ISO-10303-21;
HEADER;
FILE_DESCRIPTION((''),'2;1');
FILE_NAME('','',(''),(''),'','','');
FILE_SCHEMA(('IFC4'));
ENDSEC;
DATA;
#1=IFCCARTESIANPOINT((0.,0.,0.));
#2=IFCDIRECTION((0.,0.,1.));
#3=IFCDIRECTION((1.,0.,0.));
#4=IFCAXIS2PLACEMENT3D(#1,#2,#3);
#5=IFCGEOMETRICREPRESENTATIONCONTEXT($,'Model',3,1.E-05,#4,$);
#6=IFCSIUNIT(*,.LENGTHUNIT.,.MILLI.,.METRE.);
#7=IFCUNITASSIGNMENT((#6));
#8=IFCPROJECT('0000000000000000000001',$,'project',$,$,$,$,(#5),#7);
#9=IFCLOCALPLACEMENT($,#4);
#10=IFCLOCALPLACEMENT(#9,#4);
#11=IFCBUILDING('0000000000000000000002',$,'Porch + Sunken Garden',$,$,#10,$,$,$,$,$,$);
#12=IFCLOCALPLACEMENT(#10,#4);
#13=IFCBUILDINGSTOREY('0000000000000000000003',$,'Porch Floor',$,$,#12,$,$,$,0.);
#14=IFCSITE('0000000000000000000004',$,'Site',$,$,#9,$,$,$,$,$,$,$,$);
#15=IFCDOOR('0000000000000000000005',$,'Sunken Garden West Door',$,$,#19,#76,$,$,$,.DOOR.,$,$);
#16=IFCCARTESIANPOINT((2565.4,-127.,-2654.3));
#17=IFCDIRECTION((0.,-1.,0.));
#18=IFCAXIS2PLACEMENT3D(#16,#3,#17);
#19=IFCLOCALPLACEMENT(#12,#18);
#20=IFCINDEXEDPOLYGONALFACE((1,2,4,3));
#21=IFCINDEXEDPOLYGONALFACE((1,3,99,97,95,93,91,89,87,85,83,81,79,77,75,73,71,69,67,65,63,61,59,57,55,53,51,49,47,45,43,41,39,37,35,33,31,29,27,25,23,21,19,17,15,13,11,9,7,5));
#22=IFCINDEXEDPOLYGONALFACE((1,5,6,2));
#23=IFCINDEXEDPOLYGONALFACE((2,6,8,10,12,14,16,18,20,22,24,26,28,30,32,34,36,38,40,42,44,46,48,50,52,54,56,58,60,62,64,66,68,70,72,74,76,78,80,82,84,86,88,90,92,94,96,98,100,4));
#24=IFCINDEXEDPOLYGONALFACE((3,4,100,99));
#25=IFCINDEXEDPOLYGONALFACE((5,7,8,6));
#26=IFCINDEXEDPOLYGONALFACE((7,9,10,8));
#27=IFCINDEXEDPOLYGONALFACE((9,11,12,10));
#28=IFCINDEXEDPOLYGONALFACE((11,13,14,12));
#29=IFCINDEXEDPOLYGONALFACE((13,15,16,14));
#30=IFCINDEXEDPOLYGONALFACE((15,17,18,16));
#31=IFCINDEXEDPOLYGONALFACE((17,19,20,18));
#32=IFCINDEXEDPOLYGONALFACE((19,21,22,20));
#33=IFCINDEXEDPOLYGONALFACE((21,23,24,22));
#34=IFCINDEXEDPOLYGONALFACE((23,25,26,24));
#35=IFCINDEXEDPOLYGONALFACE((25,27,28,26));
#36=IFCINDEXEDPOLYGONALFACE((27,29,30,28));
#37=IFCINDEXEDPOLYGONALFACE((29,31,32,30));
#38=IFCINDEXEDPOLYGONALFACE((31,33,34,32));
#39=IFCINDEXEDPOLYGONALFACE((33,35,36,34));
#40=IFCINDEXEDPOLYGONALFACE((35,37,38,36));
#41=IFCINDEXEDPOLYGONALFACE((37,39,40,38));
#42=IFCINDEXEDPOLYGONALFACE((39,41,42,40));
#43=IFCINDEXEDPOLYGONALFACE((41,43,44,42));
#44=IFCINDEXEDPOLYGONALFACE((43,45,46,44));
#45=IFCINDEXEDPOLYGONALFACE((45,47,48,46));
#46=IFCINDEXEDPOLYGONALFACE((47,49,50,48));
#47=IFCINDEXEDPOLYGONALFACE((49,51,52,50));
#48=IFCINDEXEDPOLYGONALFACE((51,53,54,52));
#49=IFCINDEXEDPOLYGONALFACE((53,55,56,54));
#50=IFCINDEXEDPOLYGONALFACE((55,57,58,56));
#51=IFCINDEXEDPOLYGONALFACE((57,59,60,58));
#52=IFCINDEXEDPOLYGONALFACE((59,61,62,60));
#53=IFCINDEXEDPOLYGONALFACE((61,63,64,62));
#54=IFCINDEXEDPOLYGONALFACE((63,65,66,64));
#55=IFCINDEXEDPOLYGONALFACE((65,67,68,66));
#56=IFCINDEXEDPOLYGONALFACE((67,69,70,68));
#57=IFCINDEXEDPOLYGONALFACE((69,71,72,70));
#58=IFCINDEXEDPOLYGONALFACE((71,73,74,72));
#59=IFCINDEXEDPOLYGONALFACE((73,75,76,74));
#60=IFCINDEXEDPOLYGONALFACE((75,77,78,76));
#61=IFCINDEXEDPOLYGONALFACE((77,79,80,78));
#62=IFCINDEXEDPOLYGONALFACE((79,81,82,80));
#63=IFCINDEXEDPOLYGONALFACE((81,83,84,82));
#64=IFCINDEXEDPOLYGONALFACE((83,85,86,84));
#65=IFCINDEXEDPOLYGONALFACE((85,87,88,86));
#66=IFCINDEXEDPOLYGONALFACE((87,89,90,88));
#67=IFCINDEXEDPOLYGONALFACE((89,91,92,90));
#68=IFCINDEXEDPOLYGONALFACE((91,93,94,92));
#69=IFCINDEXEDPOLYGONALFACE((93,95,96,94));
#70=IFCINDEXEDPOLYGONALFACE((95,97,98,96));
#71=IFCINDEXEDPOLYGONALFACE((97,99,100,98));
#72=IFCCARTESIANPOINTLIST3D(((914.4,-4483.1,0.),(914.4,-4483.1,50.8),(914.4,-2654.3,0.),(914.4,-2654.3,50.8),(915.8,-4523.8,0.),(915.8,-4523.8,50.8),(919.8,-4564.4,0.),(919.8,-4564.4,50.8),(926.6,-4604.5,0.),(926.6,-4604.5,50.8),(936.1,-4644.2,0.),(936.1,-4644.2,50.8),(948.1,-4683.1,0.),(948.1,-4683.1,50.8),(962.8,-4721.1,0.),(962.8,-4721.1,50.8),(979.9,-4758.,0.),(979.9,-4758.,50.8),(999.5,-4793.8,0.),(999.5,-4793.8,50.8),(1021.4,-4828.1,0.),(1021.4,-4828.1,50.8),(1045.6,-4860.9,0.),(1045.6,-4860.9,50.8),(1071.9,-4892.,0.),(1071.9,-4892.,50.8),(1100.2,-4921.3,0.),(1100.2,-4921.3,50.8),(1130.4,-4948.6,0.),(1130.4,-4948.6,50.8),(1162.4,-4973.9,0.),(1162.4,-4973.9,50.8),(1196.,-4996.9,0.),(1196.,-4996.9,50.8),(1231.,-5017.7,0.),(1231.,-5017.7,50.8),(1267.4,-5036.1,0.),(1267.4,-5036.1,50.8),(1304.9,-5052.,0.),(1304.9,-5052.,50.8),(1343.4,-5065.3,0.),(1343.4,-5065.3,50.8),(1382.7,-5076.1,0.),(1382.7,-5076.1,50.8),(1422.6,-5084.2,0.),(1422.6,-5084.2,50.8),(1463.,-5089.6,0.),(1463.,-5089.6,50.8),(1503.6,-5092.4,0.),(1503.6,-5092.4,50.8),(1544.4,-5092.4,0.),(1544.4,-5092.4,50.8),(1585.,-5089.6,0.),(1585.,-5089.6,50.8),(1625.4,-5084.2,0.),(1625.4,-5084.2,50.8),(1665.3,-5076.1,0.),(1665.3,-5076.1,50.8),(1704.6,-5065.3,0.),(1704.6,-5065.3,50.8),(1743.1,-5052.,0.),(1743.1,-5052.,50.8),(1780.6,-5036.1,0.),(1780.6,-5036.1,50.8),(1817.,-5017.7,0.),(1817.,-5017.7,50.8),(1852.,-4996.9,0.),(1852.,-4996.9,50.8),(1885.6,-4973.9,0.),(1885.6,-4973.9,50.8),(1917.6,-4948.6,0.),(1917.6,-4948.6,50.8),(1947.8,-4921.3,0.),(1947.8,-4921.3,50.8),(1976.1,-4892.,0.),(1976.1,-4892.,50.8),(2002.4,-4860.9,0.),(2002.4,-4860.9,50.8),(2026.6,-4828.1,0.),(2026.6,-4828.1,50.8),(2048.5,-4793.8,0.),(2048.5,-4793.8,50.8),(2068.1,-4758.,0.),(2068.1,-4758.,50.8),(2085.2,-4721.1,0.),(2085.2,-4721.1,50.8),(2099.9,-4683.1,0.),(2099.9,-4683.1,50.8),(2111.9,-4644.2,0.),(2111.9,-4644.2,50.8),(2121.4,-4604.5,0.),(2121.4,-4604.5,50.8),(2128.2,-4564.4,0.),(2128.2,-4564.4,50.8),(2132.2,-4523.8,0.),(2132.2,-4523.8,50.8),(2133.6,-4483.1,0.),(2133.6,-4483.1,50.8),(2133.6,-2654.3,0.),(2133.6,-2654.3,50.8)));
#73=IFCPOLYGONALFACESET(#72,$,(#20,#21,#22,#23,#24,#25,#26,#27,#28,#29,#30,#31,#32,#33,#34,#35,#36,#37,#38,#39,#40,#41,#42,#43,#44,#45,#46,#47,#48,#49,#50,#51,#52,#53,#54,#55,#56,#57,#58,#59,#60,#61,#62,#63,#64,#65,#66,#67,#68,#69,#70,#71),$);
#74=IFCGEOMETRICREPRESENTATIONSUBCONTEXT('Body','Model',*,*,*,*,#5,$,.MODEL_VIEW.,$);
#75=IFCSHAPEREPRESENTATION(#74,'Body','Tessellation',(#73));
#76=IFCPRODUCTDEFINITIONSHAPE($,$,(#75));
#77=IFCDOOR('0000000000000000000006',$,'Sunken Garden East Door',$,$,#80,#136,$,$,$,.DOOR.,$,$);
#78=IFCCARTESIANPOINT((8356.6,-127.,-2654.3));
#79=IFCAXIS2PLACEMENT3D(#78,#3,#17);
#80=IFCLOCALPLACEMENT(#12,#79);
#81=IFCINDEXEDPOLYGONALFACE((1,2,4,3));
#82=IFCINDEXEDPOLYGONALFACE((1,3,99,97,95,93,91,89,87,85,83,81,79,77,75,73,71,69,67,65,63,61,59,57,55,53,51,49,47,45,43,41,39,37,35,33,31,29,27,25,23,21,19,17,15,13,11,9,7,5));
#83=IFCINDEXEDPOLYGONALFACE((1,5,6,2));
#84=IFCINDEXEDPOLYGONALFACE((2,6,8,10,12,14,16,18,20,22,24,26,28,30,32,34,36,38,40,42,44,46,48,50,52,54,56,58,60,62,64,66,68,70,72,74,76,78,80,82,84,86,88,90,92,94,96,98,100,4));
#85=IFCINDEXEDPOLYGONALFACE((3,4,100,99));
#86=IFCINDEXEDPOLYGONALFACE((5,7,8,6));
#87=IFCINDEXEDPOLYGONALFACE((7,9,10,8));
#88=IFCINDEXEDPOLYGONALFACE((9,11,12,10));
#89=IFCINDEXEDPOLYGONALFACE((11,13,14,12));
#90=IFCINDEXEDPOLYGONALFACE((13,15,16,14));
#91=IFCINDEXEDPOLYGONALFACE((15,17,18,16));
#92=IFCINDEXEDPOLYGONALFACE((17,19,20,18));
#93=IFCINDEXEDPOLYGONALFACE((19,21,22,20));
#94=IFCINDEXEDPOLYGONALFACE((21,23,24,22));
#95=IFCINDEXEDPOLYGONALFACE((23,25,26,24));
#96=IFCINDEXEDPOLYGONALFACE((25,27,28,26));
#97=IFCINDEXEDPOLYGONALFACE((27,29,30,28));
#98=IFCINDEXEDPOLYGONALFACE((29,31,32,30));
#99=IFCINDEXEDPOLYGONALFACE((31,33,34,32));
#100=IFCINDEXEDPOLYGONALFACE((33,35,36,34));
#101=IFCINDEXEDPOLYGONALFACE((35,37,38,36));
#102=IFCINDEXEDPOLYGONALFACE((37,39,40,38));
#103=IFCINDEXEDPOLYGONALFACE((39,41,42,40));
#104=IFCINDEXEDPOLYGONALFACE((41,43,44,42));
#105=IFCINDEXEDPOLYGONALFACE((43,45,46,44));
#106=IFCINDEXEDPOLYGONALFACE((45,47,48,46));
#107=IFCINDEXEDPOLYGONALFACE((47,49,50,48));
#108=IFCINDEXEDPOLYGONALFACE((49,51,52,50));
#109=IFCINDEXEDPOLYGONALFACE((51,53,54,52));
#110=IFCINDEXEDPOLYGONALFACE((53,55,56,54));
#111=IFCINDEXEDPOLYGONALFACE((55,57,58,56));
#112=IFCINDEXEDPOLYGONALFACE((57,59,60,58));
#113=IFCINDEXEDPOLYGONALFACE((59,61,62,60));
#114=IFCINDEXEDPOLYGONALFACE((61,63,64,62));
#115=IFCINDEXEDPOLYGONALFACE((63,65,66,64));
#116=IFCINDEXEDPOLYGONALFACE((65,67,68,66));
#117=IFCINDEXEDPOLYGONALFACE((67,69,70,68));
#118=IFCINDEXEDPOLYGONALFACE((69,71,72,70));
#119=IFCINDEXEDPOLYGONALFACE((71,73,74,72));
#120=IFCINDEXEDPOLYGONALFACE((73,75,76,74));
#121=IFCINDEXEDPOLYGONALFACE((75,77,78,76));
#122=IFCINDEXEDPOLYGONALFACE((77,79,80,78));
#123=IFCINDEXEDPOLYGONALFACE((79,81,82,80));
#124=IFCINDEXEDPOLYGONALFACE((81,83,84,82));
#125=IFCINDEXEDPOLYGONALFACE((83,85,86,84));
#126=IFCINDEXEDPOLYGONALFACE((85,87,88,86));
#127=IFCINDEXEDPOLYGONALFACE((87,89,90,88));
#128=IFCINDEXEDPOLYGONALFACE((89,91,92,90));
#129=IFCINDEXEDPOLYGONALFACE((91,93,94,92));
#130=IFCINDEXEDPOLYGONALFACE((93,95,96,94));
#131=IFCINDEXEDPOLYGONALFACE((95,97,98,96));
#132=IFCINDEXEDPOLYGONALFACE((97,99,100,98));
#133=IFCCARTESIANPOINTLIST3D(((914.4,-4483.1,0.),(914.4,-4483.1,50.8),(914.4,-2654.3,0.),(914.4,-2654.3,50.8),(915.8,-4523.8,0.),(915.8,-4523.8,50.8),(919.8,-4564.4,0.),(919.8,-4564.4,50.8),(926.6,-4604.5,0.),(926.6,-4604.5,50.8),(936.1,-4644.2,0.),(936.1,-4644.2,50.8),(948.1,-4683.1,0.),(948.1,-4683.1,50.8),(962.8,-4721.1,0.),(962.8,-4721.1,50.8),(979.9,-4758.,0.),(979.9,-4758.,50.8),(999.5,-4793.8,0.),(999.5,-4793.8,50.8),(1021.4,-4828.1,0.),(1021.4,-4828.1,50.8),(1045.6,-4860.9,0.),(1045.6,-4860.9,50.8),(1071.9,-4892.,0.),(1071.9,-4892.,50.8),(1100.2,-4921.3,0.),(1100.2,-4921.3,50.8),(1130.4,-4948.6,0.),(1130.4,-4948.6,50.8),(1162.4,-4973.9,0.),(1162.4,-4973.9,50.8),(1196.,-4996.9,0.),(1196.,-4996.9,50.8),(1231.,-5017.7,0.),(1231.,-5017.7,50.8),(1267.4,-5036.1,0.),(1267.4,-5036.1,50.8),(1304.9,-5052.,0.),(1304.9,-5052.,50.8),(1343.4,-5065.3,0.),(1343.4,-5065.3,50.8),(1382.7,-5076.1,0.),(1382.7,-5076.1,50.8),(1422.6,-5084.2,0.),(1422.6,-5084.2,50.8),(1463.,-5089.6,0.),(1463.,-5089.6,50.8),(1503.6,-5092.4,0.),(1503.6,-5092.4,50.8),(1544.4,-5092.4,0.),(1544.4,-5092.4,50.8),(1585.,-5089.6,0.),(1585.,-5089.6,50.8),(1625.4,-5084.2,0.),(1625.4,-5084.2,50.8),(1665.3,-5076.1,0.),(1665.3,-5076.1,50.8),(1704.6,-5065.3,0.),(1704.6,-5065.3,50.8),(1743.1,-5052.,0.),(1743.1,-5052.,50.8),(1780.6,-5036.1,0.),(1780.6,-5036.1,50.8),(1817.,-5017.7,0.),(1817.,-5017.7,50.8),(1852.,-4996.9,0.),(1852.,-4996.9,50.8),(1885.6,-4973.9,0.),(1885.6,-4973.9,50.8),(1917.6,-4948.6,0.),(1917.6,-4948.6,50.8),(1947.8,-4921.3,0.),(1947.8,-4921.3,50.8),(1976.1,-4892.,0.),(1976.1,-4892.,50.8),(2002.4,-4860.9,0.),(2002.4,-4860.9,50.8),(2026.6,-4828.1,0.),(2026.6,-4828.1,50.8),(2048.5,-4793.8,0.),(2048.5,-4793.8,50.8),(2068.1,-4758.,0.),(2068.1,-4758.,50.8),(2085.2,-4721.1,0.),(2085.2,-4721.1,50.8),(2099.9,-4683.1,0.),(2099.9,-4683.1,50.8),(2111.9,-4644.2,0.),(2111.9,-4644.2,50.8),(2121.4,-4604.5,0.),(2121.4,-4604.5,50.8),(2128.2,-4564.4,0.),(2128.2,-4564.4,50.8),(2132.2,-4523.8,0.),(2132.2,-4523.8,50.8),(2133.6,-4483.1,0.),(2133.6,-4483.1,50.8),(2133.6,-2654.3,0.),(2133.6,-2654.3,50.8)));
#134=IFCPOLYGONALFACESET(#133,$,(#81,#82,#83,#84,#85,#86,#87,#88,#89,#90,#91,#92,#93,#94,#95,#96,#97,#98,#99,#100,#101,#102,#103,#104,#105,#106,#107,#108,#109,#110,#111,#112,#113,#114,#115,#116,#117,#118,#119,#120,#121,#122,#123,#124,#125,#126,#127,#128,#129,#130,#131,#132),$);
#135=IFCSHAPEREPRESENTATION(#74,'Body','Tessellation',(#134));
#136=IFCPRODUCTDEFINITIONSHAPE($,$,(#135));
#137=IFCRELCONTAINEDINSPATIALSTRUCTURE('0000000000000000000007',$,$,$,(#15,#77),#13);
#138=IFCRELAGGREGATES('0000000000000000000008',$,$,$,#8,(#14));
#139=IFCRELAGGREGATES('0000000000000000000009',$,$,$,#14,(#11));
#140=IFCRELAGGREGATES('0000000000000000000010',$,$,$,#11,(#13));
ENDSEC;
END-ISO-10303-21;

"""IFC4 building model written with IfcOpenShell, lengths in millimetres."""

from ifc_helpers import new_model, si_unit, frame, origin_with_axes, place, context, subcontext, project, spatial, indexed_curve, outline, extrude, element, save


model = new_model("IFC4")

# Units and contexts
model_context = context("Model", 3, precision=1e-05, world=origin_with_axes())
body_context = subcontext(model_context, "Body", "Model", "MODEL_VIEW")
ifc_project = project(units=[si_unit("LENGTHUNIT", "METRE", prefix="MILLI")], contexts=[model_context])

# Site, building, storey
site_placement = place(None, origin_with_axes())
site = spatial("IfcSite", under=ifc_project, at=site_placement, Name="Site")
building_placement = place(site_placement, origin_with_axes())
building = spatial("IfcBuilding", under=site, at=building_placement, Name="Porch + Sunken Garden")
storey_placement = place(building_placement, origin_with_axes())
storey = spatial("IfcBuildingStorey", under=building, at=storey_placement, Name="Porch Floor", Elevation=0.0)

# Doors
door_1_placement = place(storey_placement, frame((2565.4, -127.0, -2654.3), z_axis=(1.0, 0.0, 0.0), x_axis=(0.0, -1.0, 0.0)))
element("IfcDoor", 1, at=door_1_placement, inside=storey, Name="Sunken Garden West Door", PredefinedType="DOOR", context=body_context, shape_type="SweptSolid", body=[
    extrude(outline(indexed_curve([(914.4, -2654.3), (914.4, -4483.1), (914.4, -4483.1), (915.8, -4523.8), (919.8, -4564.4), (926.6, -4604.5), (936.1, -4644.2), (948.1, -4683.1), (962.8, -4721.1), (979.9, -4758.0), (999.5, -4793.8), (1021.4, -4828.1), (1045.6, -4860.9), (1071.9, -4892.0), (1100.2, -4921.3), (1130.4, -4948.6), (1162.4, -4973.9), (1196.0, -4996.9), (1231.0, -5017.7), (1267.4, -5036.1), (1304.9, -5052.0), (1343.4, -5065.3), (1382.7, -5076.1), (1422.6, -5084.2), (1463.0, -5089.6), (1503.6, -5092.4), (1544.4, -5092.4), (1585.0, -5089.6), (1625.4, -5084.2), (1665.3, -5076.1), (1704.6, -5065.3), (1743.1, -5052.0), (1780.6, -5036.1), (1817.0, -5017.7), (1852.0, -4996.9), (1885.6, -4973.9), (1917.6, -4948.6), (1947.8, -4921.3), (1976.1, -4892.0), (2002.4, -4860.9), (2026.6, -4828.1), (2048.5, -4793.8), (2068.1, -4758.0), (2085.2, -4721.1), (2099.9, -4683.1), (2111.9, -4644.2), (2121.4, -4604.5), (2128.2, -4564.4), (2132.2, -4523.8), (2133.6, -4483.1), (2133.6, -2654.3), (914.4, -2654.3)])), origin_with_axes(), (0.0, 0.0, 1.0), 50.8),
])
door_2_placement = place(storey_placement, frame((8356.6, -127.0, -2654.3), z_axis=(1.0, 0.0, 0.0), x_axis=(0.0, -1.0, 0.0)))
element("IfcDoor", 2, at=door_2_placement, inside=storey, Name="Sunken Garden East Door", PredefinedType="DOOR", context=body_context, shape_type="SweptSolid", body=[
    extrude(outline(indexed_curve([(914.4, -2654.3), (914.4, -4483.1), (914.4, -4483.1), (915.8, -4523.8), (919.8, -4564.4), (926.6, -4604.5), (936.1, -4644.2), (948.1, -4683.1), (962.8, -4721.1), (979.9, -4758.0), (999.5, -4793.8), (1021.4, -4828.1), (1045.6, -4860.9), (1071.9, -4892.0), (1100.2, -4921.3), (1130.4, -4948.6), (1162.4, -4973.9), (1196.0, -4996.9), (1231.0, -5017.7), (1267.4, -5036.1), (1304.9, -5052.0), (1343.4, -5065.3), (1382.7, -5076.1), (1422.6, -5084.2), (1463.0, -5089.6), (1503.6, -5092.4), (1544.4, -5092.4), (1585.0, -5089.6), (1625.4, -5084.2), (1665.3, -5076.1), (1704.6, -5065.3), (1743.1, -5052.0), (1780.6, -5036.1), (1817.0, -5017.7), (1852.0, -4996.9), (1885.6, -4973.9), (1917.6, -4948.6), (1947.8, -4921.3), (1976.1, -4892.0), (2002.4, -4860.9), (2026.6, -4828.1), (2048.5, -4793.8), (2068.1, -4758.0), (2085.2, -4721.1), (2099.9, -4683.1), (2111.9, -4644.2), (2121.4, -4604.5), (2128.2, -4564.4), (2132.2, -4523.8), (2133.6, -4483.1), (2133.6, -2654.3), (914.4, -2654.3)])), origin_with_axes(), (0.0, 0.0, 1.0), 50.8),
])

save(model, "model.ifc")
